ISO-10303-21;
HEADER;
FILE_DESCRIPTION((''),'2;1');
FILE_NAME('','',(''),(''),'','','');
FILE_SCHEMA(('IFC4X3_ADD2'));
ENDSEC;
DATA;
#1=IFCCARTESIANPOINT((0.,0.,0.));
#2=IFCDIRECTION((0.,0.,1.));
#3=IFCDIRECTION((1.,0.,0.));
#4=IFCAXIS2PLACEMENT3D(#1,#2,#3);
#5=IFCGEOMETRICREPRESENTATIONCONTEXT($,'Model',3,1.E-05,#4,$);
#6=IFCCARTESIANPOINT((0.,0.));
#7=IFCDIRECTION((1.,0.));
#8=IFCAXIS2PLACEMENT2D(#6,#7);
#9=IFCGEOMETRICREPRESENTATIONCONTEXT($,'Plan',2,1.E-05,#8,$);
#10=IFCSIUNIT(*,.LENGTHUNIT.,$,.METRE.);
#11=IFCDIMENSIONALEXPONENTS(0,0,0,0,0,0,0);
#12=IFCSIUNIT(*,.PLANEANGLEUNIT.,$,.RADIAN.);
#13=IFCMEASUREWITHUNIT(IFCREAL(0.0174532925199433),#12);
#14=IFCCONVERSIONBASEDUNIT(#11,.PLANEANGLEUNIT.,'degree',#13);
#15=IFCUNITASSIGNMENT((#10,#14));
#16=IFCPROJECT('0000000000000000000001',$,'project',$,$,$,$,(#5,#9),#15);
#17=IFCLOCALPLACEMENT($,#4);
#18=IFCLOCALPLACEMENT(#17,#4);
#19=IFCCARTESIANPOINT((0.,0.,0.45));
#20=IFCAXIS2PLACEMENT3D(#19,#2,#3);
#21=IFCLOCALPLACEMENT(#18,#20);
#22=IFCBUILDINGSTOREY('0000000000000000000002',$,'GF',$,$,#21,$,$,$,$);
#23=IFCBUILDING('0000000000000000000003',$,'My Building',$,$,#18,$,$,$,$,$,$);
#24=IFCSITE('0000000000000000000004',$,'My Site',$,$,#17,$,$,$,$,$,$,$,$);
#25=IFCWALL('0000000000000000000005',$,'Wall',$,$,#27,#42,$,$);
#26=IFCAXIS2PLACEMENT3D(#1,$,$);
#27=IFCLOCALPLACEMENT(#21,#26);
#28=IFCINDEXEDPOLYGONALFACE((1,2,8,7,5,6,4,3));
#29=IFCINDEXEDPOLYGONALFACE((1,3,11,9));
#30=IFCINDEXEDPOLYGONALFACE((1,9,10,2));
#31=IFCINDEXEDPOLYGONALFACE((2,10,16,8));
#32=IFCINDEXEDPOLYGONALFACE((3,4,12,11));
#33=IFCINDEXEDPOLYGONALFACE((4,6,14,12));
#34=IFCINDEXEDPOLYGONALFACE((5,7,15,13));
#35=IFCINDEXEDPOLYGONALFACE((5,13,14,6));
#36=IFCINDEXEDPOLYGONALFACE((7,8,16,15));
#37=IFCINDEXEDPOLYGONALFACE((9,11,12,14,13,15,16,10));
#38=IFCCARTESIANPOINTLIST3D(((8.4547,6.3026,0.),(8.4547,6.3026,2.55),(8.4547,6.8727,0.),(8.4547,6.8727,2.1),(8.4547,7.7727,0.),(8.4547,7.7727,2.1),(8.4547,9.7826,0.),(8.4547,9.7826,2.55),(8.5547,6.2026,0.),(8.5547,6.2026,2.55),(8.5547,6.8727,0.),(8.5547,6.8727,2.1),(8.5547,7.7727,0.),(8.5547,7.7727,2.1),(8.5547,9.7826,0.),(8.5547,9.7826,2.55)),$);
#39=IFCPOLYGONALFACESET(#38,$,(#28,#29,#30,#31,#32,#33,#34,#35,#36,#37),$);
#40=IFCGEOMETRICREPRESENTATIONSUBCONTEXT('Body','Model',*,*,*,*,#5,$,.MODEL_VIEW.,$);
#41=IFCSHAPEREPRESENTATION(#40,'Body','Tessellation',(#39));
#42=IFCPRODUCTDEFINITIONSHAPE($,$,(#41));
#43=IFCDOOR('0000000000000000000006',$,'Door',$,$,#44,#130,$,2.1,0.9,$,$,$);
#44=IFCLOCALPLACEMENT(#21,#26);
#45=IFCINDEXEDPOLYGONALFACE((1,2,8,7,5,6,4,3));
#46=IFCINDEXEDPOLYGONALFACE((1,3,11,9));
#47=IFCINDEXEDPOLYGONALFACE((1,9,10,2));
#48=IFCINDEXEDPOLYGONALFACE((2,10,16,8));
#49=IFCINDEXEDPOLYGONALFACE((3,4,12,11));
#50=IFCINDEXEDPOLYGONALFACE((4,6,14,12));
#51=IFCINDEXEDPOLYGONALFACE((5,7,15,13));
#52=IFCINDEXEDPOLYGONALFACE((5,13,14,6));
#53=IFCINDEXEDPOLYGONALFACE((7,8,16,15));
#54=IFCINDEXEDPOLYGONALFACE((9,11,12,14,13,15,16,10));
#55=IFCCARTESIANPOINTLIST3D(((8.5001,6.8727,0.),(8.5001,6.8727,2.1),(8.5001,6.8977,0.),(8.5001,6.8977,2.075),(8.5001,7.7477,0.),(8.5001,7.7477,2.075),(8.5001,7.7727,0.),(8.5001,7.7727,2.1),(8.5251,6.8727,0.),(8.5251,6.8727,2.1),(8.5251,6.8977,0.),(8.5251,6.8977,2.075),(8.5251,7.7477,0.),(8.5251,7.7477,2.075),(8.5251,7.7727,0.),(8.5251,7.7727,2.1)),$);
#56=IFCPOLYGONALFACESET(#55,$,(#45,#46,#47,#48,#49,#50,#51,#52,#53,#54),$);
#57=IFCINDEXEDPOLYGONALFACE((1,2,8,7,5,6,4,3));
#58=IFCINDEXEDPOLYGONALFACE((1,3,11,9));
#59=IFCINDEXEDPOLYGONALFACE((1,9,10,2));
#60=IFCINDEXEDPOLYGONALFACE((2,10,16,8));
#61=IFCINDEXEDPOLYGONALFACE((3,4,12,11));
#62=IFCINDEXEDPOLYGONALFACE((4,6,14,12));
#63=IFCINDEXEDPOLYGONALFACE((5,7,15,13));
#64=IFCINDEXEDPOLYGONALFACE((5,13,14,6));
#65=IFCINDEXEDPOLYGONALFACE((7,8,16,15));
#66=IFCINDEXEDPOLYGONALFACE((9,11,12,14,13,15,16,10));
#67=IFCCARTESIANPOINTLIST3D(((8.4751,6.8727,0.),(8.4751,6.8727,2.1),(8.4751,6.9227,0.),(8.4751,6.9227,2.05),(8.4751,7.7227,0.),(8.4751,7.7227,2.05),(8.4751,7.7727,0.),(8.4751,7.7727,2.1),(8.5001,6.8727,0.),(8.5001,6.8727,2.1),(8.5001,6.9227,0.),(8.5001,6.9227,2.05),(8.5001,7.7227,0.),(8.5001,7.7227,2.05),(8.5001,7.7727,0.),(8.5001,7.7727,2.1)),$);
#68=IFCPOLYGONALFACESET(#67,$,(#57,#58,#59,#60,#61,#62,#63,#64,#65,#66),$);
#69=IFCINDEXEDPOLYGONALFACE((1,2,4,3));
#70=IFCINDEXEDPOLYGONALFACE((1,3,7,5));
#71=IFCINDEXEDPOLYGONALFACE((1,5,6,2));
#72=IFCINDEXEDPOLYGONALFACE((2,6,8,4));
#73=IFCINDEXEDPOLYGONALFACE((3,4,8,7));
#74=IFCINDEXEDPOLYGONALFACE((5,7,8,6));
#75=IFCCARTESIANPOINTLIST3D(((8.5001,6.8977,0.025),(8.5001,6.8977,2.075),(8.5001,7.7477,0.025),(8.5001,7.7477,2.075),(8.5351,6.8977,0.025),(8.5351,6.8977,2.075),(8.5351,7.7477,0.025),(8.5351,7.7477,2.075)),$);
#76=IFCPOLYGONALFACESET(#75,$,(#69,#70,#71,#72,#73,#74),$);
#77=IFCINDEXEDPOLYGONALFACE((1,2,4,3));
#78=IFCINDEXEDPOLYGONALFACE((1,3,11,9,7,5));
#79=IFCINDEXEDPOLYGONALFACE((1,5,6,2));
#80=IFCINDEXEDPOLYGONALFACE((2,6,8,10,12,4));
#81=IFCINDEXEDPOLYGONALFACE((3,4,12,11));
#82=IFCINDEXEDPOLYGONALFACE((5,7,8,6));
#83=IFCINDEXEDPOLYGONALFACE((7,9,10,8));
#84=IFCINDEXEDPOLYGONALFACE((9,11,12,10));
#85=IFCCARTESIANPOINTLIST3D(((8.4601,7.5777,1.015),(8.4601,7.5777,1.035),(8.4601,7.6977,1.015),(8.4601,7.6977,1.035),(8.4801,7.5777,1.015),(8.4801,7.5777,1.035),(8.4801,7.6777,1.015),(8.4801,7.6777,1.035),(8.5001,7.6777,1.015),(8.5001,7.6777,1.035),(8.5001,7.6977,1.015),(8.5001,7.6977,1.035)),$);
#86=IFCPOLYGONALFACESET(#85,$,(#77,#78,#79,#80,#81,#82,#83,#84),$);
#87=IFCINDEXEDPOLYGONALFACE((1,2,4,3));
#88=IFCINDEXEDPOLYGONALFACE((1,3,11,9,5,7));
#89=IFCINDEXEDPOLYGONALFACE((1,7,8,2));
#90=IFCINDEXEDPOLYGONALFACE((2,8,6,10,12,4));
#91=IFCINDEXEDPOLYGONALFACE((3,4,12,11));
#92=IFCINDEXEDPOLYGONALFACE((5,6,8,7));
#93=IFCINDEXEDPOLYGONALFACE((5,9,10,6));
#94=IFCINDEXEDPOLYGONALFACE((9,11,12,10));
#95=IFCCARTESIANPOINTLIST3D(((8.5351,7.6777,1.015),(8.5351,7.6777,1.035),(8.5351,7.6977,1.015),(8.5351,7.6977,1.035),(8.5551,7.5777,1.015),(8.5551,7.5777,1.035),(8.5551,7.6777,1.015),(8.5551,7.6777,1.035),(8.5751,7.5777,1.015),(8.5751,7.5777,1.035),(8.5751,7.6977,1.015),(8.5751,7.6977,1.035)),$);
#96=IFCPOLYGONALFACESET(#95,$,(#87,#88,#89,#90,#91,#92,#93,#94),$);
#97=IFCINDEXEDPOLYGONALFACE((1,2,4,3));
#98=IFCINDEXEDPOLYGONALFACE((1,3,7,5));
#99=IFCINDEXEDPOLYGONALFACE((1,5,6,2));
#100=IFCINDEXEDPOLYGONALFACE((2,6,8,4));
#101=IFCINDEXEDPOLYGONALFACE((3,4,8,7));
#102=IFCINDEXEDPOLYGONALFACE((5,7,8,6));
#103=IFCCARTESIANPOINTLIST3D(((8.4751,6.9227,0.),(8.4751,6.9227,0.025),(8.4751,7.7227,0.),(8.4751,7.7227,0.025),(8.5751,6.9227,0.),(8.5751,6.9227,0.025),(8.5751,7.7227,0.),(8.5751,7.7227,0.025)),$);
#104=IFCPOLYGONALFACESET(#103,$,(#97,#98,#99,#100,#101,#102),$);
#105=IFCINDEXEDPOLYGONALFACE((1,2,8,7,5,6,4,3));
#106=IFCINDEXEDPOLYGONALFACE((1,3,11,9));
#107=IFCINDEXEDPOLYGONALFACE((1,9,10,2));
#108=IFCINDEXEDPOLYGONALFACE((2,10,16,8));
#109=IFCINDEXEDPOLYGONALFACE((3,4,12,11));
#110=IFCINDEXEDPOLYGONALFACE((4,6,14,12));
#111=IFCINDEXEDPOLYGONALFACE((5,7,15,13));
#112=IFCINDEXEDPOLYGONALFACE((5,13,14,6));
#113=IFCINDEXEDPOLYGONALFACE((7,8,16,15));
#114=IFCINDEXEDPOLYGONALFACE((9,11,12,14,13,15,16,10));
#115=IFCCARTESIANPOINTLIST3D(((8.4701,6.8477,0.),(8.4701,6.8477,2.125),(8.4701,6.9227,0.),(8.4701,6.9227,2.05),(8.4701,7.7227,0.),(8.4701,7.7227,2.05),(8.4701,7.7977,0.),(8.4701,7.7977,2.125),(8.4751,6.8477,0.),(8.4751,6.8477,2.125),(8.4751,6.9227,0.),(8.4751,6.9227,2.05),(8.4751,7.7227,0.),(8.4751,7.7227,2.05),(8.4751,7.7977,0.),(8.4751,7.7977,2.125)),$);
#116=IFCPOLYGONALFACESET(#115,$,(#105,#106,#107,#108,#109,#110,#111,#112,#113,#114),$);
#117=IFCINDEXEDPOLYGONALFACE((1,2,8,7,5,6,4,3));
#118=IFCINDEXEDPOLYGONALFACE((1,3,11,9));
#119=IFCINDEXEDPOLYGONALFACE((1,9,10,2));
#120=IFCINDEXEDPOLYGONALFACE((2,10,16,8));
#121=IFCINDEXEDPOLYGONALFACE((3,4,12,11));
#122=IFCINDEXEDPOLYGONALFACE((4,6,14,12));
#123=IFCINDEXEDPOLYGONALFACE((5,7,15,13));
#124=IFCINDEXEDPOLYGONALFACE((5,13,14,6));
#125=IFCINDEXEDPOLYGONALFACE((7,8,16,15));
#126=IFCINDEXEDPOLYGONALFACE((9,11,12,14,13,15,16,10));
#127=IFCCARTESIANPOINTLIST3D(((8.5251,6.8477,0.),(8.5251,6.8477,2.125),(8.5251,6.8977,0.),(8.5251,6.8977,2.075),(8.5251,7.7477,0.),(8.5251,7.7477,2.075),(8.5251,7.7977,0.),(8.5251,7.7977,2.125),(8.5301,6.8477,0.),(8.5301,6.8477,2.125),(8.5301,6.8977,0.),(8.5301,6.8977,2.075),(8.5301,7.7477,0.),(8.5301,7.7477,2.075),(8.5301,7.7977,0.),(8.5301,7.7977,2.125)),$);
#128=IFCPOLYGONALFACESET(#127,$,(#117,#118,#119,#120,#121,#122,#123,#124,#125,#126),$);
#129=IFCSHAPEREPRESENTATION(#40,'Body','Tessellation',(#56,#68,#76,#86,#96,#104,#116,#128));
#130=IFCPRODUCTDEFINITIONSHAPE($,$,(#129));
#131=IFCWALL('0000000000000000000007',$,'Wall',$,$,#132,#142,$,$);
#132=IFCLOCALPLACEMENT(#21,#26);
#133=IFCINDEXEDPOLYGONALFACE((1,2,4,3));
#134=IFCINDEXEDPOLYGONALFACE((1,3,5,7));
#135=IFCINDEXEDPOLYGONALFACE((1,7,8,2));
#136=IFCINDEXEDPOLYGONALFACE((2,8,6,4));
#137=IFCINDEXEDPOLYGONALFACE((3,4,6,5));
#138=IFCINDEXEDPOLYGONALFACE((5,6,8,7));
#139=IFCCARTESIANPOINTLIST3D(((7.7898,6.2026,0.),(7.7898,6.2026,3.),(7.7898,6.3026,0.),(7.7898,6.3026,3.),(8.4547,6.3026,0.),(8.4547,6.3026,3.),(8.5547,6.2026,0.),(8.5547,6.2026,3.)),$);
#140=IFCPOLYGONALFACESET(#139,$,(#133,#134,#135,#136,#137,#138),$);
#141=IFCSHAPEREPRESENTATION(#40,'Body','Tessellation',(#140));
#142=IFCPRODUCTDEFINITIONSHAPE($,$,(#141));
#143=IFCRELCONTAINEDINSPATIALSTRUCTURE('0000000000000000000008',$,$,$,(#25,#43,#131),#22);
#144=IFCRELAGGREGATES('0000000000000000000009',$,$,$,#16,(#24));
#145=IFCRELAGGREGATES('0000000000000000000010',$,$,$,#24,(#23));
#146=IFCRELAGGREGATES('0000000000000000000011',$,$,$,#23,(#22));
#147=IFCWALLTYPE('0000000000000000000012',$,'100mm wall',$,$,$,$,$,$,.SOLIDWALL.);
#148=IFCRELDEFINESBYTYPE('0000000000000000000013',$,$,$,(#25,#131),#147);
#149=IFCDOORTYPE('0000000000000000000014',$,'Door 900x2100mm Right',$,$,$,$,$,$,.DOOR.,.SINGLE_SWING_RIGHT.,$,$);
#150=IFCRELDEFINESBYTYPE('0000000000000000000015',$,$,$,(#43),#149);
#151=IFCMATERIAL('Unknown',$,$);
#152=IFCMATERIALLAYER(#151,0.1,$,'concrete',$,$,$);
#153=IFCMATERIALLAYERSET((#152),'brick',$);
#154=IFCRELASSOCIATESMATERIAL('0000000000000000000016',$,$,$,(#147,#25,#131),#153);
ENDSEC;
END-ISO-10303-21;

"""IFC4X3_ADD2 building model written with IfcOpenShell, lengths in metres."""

from ifc_helpers import new_model, entity, si_unit, converted_unit, frame, origin_with_axes, origin_2d_with_axis, place, context, subcontext, project, spatial, line, indexed_curve, outline, extrude, shape, source, transform, mapped, material, layer, layer_set, layer_usage, type_object, type_shapes, element, fill, save


model = new_model("IFC4X3_ADD2")

# Units and contexts
model_context = context("Model", 3, precision=1e-05, world=origin_with_axes())
plan_context = context("Plan", 2, precision=1e-05, world=origin_2d_with_axis())
body_context_1 = subcontext(model_context, "Body", "Model", "MODEL_VIEW")
body_context_2 = subcontext(plan_context, "Body", "Plan", "PLAN_VIEW")
ifc_project = project(units=[si_unit("LENGTHUNIT", "METRE"), converted_unit("PLANEANGLEUNIT", "degree", entity("IfcReal", 0.0174532925199433), si_unit("PLANEANGLEUNIT", "RADIAN"), dimensions=[0, 0, 0, 0, 0, 0, 0])], contexts=[model_context, plan_context])

# Site, building, storey
site_placement = place(None, origin_with_axes())
site = spatial("IfcSite", under=ifc_project, at=site_placement, Name="My Site")
building_placement = place(site_placement, origin_with_axes())
building = spatial("IfcBuilding", under=site, at=building_placement, Name="My Building")
storey_placement = place(building_placement, frame((0.0, 0.0, 0.45), z_axis=(0.0, 0.0, 1.0), x_axis=(1.0, 0.0, 0.0)))
storey = spatial("IfcBuildingStorey", under=building, at=storey_placement, Name="GF")

# Shared definitions
ifc_material_1 = material(Name="Unknown")

# Shared definitions
ifc_layer_1 = layer(ifc_material_1, 0.1, Name="concrete")
ifc_layer_set_1 = layer_set([ifc_layer_1], Name="brick")
wall_type_1 = type_object("IfcWallType", Name="100mm wall", PredefinedType="SOLIDWALL", material=ifc_layer_set_1)

# Wall, opening, door
ifc_layer_usage_1 = layer_usage(ifc_layer_set_1, "AXIS2", "POSITIVE", 0.0)
wall_1_placement = place(storey_placement, frame((8.5547, 6.2026, 0.0), z_axis=(0.0, 0.0, 1.0), x_axis=(0.0, 1.0, 0.0)))
wall_1 = element("IfcWall", 1, at=wall_1_placement, inside=storey, type_object=wall_type_1, material=ifc_layer_usage_1, Name="Wall", context=body_context_1, shape_type="SweptSolid", body=[
    extrude(outline(indexed_curve([(0.0, 0.0), (0.1, 0.1), (3.58, 0.1), (3.58, 0.0)], segments=[line(1, 2, 3, 4, 1)])), origin_with_axes(), (0.0, 0.0, 1.0), 2.55),
])
shared_shape_1 = source(origin_with_axes(), body_context_1, "Body", "SolidModel", [
    extrude(outline(indexed_curve([(0.0, 0.0), (0.9, 0.0), (0.9, 2.1), (0.0, 2.1)], segments=[line(1, 2, 3, 4, 1)])), frame((0.0, -0.6, 0.0), z_axis=(0.0, -1.0, 0.0), x_axis=(1.0, 0.0, 0.0)), (0.0, 0.0, -1.0), 1.2),
])
opening_1_placement = place(wall_1_placement, frame((1.5702, 0.0796, 0.0), z_axis=(0.0, 0.0, 1.0), x_axis=(-1.0, 0.0, 0.0)))
opening_1 = element("IfcOpeningElement", 2, at=opening_1_placement, cuts=wall_1, PredefinedType="OPENING", context=body_context_1, shape_type="MappedRepresentation", body=[
    mapped(shared_shape_1, transform((0.0, 0.0, 0.0), x_axis=(1.0, 0.0, 0.0), y_axis=(0.0, 1.0, 0.0), z_axis=(0.0, 0.0, 1.0), scale=1.0)),
])
door_type_1 = type_object("IfcDoorType", Name="Door 900x2100mm Right", OperationType="SINGLE_SWING_RIGHT", PredefinedType="DOOR")
shared_shape_2 = source(origin_with_axes(), body_context_1, "Body", "SweptSolid", [
    extrude(outline(indexed_curve([(0.0, 0.0), (0.0, 2.1), (0.9, 2.1), (0.9, 0.0), (0.875, 0.0), (0.875, 2.075), (0.025, 2.075), (0.025, 0.0)], segments=[line(1, 2, 3, 4, 5, 6, 7, 8, 1)])), frame((0.0, 0.025, 0.0), z_axis=(0.0, -1.0, 0.0), x_axis=(1.0, 0.0, 0.0)), (0.0, 0.0, -1.0), 0.025),
    extrude(outline(indexed_curve([(0.0, 0.0), (0.0, 2.1), (0.9, 2.1), (0.9, 0.0), (0.85, 0.0), (0.85, 2.05), (0.05, 2.05), (0.05, 0.0)], segments=[line(1, 2, 3, 4, 5, 6, 7, 8, 1)])), frame((0.0, 0.0, 0.0), z_axis=(0.0, -1.0, 0.0), x_axis=(1.0, 0.0, 0.0)), (0.0, 0.0, -1.0), 0.025),
    extrude(outline(indexed_curve([(0.0, 0.0), (0.85, 0.0), (0.85, 0.035), (0.0, 0.035)], segments=[line(1, 2, 3, 4, 1)])), frame((0.025, 0.025, 0.025), z_axis=(0.0, 0.0, 1.0), x_axis=(1.0, 0.0, 0.0)), (0.0, 0.0, 1.0), 2.05),
    extrude(outline(indexed_curve([(0.0, 0.0), (0.0, -0.04), (0.12, -0.04), (0.12, -0.02), (0.02, -0.02), (0.02, 0.0)], segments=[line(1, 2, 3, 4, 5, 6, 1)])), frame((0.075, 0.025, 1.015), z_axis=(0.0, 0.0, 1.0), x_axis=(1.0, 0.0, 0.0)), (0.0, 0.0, 1.0), 0.02),
    extrude(outline(indexed_curve([(0.0, 0.0), (0.0, 0.04), (0.12, 0.04), (0.12, 0.02), (0.02, 0.02), (0.02, 0.0)], segments=[line(1, 2, 3, 4, 5, 6, 1)])), frame((0.075, 0.06, 1.015), z_axis=(0.0, 0.0, 1.0), x_axis=(1.0, 0.0, 0.0)), (0.0, 0.0, 1.0), 0.02),
    extrude(outline(indexed_curve([(0.0, 0.0), (0.8, 0.0), (0.8, 0.1), (0.0, 0.1)], segments=[line(1, 2, 3, 4, 1)])), frame((0.05, 0.0, 0.0), z_axis=(0.0, 0.0, 1.0), x_axis=(1.0, 0.0, 0.0)), (0.0, 0.0, 1.0), 0.025),
    extrude(outline(indexed_curve([(0.0, 0.0), (0.0, 2.125), (0.95, 2.125), (0.95, 0.0), (0.875, 0.0), (0.875, 2.05), (0.075, 2.05), (0.075, 0.0)], segments=[line(1, 2, 3, 4, 5, 6, 7, 8, 1)])), frame((-0.025, -0.005, 0.0), z_axis=(0.0, -1.0, 0.0), x_axis=(1.0, 0.0, 0.0)), (0.0, 0.0, -1.0), 0.005),
    extrude(outline(indexed_curve([(0.0, 0.0), (0.0, 2.125), (0.95, 2.125), (0.95, 0.0), (0.9, 0.0), (0.9, 2.075), (0.05, 2.075), (0.05, 0.0)], segments=[line(1, 2, 3, 4, 5, 6, 7, 8, 1)])), frame((-0.025, 0.05, 0.0), z_axis=(0.0, -1.0, 0.0), x_axis=(1.0, 0.0, 0.0)), (0.0, 0.0, -1.0), 0.005),
])
shared_shape_3 = source(origin_with_axes(), body_context_2, "Body", "Curve2D", [
    entity("IfcIndexedPolyCurve", entity("IfcCartesianPointList2D", [[0.0, 0.0], [0.0, 0.05], [0.025, 0.05], [0.025, 0.025], [0.05, 0.025], [0.05, 0.0]]), [entity("IfcLineIndex", [1, 2, 3, 4, 5, 6, 1])]),
    entity("IfcIndexedPolyCurve", entity("IfcCartesianPointList2D", [[0.9, 0.0], [0.9, 0.05], [0.875, 0.05], [0.875, 0.025], [0.85, 0.025], [0.85, 0.0]]), [entity("IfcLineIndex", [1, 2, 3, 4, 5, 6, 1])]),
    entity("IfcTrimmedCurve", entity("IfcEllipse", entity("IfcAxis2Placement2D", entity("IfcCartesianPoint", [0.84, 0.05]), entity("IfcDirection", [1.0, 0.0])), 0.815, 0.85), [entity("IfcCartesianPoint", [0.84, 0.9])], [entity("IfcCartesianPoint", [0.025, 0.05])], True, "CARTESIAN"),
    entity("IfcIndexedPolyCurve", entity("IfcCartesianPointList2D", [[0.875, 0.05], [0.84, 0.05], [0.84, 0.9], [0.875, 0.9]]), [entity("IfcLineIndex", [1, 2, 3, 4, 1])]),
])
type_shapes(door_type_1, [shared_shape_2, shared_shape_3])
door_1_placement = place(opening_1_placement, frame((0.0, 0.0, 0.0), z_axis=(0.0, 0.0, 1.0), x_axis=(1.0, 0.0, 0.0)))
door_1 = element("IfcDoor", 3, at=door_1_placement, inside=storey, type_object=door_type_1, Name="Door", OverallHeight=2.1, OverallWidth=0.9, shapes=[
    shape(body_context_1, "Body", "MappedRepresentation", [mapped(shared_shape_2, transform((0.0, 0.0, 0.0), x_axis=(1.0, 0.0, 0.0), y_axis=(0.0, 1.0, 0.0), z_axis=(0.0, 0.0, 1.0), scale=1.0))]),
    shape(body_context_2, "Body", "MappedRepresentation", [mapped(shared_shape_3, transform((0.0, 0.0, 0.0), x_axis=(1.0, 0.0, 0.0), y_axis=(0.0, 1.0, 0.0), z_axis=(0.0, 0.0, 1.0), scale=1.0))]),
])
fill(opening_1, door_1)

# Wall
ifc_layer_usage_2 = layer_usage(ifc_layer_set_1, "AXIS2", "POSITIVE", 0.0)
wall_2_placement = place(storey_placement, frame((7.7898, 6.2026, 0.0), z_axis=(0.0, 0.0, 1.0), x_axis=(1.0, 0.0, 0.0)))
element("IfcWall", 4, at=wall_2_placement, inside=storey, type_object=wall_type_1, material=ifc_layer_usage_2, Name="Wall", context=body_context_1, shape_type="SweptSolid", body=[
    extrude(outline(indexed_curve([(0.0, 0.0), (0.0, 0.1), (0.6649, 0.1), (0.7649, 0.0)], segments=[line(1, 2, 3, 4, 1)])), origin_with_axes(), (0.0, 0.0, 1.0), 3.0),
])

save(model, "model.ifc")
